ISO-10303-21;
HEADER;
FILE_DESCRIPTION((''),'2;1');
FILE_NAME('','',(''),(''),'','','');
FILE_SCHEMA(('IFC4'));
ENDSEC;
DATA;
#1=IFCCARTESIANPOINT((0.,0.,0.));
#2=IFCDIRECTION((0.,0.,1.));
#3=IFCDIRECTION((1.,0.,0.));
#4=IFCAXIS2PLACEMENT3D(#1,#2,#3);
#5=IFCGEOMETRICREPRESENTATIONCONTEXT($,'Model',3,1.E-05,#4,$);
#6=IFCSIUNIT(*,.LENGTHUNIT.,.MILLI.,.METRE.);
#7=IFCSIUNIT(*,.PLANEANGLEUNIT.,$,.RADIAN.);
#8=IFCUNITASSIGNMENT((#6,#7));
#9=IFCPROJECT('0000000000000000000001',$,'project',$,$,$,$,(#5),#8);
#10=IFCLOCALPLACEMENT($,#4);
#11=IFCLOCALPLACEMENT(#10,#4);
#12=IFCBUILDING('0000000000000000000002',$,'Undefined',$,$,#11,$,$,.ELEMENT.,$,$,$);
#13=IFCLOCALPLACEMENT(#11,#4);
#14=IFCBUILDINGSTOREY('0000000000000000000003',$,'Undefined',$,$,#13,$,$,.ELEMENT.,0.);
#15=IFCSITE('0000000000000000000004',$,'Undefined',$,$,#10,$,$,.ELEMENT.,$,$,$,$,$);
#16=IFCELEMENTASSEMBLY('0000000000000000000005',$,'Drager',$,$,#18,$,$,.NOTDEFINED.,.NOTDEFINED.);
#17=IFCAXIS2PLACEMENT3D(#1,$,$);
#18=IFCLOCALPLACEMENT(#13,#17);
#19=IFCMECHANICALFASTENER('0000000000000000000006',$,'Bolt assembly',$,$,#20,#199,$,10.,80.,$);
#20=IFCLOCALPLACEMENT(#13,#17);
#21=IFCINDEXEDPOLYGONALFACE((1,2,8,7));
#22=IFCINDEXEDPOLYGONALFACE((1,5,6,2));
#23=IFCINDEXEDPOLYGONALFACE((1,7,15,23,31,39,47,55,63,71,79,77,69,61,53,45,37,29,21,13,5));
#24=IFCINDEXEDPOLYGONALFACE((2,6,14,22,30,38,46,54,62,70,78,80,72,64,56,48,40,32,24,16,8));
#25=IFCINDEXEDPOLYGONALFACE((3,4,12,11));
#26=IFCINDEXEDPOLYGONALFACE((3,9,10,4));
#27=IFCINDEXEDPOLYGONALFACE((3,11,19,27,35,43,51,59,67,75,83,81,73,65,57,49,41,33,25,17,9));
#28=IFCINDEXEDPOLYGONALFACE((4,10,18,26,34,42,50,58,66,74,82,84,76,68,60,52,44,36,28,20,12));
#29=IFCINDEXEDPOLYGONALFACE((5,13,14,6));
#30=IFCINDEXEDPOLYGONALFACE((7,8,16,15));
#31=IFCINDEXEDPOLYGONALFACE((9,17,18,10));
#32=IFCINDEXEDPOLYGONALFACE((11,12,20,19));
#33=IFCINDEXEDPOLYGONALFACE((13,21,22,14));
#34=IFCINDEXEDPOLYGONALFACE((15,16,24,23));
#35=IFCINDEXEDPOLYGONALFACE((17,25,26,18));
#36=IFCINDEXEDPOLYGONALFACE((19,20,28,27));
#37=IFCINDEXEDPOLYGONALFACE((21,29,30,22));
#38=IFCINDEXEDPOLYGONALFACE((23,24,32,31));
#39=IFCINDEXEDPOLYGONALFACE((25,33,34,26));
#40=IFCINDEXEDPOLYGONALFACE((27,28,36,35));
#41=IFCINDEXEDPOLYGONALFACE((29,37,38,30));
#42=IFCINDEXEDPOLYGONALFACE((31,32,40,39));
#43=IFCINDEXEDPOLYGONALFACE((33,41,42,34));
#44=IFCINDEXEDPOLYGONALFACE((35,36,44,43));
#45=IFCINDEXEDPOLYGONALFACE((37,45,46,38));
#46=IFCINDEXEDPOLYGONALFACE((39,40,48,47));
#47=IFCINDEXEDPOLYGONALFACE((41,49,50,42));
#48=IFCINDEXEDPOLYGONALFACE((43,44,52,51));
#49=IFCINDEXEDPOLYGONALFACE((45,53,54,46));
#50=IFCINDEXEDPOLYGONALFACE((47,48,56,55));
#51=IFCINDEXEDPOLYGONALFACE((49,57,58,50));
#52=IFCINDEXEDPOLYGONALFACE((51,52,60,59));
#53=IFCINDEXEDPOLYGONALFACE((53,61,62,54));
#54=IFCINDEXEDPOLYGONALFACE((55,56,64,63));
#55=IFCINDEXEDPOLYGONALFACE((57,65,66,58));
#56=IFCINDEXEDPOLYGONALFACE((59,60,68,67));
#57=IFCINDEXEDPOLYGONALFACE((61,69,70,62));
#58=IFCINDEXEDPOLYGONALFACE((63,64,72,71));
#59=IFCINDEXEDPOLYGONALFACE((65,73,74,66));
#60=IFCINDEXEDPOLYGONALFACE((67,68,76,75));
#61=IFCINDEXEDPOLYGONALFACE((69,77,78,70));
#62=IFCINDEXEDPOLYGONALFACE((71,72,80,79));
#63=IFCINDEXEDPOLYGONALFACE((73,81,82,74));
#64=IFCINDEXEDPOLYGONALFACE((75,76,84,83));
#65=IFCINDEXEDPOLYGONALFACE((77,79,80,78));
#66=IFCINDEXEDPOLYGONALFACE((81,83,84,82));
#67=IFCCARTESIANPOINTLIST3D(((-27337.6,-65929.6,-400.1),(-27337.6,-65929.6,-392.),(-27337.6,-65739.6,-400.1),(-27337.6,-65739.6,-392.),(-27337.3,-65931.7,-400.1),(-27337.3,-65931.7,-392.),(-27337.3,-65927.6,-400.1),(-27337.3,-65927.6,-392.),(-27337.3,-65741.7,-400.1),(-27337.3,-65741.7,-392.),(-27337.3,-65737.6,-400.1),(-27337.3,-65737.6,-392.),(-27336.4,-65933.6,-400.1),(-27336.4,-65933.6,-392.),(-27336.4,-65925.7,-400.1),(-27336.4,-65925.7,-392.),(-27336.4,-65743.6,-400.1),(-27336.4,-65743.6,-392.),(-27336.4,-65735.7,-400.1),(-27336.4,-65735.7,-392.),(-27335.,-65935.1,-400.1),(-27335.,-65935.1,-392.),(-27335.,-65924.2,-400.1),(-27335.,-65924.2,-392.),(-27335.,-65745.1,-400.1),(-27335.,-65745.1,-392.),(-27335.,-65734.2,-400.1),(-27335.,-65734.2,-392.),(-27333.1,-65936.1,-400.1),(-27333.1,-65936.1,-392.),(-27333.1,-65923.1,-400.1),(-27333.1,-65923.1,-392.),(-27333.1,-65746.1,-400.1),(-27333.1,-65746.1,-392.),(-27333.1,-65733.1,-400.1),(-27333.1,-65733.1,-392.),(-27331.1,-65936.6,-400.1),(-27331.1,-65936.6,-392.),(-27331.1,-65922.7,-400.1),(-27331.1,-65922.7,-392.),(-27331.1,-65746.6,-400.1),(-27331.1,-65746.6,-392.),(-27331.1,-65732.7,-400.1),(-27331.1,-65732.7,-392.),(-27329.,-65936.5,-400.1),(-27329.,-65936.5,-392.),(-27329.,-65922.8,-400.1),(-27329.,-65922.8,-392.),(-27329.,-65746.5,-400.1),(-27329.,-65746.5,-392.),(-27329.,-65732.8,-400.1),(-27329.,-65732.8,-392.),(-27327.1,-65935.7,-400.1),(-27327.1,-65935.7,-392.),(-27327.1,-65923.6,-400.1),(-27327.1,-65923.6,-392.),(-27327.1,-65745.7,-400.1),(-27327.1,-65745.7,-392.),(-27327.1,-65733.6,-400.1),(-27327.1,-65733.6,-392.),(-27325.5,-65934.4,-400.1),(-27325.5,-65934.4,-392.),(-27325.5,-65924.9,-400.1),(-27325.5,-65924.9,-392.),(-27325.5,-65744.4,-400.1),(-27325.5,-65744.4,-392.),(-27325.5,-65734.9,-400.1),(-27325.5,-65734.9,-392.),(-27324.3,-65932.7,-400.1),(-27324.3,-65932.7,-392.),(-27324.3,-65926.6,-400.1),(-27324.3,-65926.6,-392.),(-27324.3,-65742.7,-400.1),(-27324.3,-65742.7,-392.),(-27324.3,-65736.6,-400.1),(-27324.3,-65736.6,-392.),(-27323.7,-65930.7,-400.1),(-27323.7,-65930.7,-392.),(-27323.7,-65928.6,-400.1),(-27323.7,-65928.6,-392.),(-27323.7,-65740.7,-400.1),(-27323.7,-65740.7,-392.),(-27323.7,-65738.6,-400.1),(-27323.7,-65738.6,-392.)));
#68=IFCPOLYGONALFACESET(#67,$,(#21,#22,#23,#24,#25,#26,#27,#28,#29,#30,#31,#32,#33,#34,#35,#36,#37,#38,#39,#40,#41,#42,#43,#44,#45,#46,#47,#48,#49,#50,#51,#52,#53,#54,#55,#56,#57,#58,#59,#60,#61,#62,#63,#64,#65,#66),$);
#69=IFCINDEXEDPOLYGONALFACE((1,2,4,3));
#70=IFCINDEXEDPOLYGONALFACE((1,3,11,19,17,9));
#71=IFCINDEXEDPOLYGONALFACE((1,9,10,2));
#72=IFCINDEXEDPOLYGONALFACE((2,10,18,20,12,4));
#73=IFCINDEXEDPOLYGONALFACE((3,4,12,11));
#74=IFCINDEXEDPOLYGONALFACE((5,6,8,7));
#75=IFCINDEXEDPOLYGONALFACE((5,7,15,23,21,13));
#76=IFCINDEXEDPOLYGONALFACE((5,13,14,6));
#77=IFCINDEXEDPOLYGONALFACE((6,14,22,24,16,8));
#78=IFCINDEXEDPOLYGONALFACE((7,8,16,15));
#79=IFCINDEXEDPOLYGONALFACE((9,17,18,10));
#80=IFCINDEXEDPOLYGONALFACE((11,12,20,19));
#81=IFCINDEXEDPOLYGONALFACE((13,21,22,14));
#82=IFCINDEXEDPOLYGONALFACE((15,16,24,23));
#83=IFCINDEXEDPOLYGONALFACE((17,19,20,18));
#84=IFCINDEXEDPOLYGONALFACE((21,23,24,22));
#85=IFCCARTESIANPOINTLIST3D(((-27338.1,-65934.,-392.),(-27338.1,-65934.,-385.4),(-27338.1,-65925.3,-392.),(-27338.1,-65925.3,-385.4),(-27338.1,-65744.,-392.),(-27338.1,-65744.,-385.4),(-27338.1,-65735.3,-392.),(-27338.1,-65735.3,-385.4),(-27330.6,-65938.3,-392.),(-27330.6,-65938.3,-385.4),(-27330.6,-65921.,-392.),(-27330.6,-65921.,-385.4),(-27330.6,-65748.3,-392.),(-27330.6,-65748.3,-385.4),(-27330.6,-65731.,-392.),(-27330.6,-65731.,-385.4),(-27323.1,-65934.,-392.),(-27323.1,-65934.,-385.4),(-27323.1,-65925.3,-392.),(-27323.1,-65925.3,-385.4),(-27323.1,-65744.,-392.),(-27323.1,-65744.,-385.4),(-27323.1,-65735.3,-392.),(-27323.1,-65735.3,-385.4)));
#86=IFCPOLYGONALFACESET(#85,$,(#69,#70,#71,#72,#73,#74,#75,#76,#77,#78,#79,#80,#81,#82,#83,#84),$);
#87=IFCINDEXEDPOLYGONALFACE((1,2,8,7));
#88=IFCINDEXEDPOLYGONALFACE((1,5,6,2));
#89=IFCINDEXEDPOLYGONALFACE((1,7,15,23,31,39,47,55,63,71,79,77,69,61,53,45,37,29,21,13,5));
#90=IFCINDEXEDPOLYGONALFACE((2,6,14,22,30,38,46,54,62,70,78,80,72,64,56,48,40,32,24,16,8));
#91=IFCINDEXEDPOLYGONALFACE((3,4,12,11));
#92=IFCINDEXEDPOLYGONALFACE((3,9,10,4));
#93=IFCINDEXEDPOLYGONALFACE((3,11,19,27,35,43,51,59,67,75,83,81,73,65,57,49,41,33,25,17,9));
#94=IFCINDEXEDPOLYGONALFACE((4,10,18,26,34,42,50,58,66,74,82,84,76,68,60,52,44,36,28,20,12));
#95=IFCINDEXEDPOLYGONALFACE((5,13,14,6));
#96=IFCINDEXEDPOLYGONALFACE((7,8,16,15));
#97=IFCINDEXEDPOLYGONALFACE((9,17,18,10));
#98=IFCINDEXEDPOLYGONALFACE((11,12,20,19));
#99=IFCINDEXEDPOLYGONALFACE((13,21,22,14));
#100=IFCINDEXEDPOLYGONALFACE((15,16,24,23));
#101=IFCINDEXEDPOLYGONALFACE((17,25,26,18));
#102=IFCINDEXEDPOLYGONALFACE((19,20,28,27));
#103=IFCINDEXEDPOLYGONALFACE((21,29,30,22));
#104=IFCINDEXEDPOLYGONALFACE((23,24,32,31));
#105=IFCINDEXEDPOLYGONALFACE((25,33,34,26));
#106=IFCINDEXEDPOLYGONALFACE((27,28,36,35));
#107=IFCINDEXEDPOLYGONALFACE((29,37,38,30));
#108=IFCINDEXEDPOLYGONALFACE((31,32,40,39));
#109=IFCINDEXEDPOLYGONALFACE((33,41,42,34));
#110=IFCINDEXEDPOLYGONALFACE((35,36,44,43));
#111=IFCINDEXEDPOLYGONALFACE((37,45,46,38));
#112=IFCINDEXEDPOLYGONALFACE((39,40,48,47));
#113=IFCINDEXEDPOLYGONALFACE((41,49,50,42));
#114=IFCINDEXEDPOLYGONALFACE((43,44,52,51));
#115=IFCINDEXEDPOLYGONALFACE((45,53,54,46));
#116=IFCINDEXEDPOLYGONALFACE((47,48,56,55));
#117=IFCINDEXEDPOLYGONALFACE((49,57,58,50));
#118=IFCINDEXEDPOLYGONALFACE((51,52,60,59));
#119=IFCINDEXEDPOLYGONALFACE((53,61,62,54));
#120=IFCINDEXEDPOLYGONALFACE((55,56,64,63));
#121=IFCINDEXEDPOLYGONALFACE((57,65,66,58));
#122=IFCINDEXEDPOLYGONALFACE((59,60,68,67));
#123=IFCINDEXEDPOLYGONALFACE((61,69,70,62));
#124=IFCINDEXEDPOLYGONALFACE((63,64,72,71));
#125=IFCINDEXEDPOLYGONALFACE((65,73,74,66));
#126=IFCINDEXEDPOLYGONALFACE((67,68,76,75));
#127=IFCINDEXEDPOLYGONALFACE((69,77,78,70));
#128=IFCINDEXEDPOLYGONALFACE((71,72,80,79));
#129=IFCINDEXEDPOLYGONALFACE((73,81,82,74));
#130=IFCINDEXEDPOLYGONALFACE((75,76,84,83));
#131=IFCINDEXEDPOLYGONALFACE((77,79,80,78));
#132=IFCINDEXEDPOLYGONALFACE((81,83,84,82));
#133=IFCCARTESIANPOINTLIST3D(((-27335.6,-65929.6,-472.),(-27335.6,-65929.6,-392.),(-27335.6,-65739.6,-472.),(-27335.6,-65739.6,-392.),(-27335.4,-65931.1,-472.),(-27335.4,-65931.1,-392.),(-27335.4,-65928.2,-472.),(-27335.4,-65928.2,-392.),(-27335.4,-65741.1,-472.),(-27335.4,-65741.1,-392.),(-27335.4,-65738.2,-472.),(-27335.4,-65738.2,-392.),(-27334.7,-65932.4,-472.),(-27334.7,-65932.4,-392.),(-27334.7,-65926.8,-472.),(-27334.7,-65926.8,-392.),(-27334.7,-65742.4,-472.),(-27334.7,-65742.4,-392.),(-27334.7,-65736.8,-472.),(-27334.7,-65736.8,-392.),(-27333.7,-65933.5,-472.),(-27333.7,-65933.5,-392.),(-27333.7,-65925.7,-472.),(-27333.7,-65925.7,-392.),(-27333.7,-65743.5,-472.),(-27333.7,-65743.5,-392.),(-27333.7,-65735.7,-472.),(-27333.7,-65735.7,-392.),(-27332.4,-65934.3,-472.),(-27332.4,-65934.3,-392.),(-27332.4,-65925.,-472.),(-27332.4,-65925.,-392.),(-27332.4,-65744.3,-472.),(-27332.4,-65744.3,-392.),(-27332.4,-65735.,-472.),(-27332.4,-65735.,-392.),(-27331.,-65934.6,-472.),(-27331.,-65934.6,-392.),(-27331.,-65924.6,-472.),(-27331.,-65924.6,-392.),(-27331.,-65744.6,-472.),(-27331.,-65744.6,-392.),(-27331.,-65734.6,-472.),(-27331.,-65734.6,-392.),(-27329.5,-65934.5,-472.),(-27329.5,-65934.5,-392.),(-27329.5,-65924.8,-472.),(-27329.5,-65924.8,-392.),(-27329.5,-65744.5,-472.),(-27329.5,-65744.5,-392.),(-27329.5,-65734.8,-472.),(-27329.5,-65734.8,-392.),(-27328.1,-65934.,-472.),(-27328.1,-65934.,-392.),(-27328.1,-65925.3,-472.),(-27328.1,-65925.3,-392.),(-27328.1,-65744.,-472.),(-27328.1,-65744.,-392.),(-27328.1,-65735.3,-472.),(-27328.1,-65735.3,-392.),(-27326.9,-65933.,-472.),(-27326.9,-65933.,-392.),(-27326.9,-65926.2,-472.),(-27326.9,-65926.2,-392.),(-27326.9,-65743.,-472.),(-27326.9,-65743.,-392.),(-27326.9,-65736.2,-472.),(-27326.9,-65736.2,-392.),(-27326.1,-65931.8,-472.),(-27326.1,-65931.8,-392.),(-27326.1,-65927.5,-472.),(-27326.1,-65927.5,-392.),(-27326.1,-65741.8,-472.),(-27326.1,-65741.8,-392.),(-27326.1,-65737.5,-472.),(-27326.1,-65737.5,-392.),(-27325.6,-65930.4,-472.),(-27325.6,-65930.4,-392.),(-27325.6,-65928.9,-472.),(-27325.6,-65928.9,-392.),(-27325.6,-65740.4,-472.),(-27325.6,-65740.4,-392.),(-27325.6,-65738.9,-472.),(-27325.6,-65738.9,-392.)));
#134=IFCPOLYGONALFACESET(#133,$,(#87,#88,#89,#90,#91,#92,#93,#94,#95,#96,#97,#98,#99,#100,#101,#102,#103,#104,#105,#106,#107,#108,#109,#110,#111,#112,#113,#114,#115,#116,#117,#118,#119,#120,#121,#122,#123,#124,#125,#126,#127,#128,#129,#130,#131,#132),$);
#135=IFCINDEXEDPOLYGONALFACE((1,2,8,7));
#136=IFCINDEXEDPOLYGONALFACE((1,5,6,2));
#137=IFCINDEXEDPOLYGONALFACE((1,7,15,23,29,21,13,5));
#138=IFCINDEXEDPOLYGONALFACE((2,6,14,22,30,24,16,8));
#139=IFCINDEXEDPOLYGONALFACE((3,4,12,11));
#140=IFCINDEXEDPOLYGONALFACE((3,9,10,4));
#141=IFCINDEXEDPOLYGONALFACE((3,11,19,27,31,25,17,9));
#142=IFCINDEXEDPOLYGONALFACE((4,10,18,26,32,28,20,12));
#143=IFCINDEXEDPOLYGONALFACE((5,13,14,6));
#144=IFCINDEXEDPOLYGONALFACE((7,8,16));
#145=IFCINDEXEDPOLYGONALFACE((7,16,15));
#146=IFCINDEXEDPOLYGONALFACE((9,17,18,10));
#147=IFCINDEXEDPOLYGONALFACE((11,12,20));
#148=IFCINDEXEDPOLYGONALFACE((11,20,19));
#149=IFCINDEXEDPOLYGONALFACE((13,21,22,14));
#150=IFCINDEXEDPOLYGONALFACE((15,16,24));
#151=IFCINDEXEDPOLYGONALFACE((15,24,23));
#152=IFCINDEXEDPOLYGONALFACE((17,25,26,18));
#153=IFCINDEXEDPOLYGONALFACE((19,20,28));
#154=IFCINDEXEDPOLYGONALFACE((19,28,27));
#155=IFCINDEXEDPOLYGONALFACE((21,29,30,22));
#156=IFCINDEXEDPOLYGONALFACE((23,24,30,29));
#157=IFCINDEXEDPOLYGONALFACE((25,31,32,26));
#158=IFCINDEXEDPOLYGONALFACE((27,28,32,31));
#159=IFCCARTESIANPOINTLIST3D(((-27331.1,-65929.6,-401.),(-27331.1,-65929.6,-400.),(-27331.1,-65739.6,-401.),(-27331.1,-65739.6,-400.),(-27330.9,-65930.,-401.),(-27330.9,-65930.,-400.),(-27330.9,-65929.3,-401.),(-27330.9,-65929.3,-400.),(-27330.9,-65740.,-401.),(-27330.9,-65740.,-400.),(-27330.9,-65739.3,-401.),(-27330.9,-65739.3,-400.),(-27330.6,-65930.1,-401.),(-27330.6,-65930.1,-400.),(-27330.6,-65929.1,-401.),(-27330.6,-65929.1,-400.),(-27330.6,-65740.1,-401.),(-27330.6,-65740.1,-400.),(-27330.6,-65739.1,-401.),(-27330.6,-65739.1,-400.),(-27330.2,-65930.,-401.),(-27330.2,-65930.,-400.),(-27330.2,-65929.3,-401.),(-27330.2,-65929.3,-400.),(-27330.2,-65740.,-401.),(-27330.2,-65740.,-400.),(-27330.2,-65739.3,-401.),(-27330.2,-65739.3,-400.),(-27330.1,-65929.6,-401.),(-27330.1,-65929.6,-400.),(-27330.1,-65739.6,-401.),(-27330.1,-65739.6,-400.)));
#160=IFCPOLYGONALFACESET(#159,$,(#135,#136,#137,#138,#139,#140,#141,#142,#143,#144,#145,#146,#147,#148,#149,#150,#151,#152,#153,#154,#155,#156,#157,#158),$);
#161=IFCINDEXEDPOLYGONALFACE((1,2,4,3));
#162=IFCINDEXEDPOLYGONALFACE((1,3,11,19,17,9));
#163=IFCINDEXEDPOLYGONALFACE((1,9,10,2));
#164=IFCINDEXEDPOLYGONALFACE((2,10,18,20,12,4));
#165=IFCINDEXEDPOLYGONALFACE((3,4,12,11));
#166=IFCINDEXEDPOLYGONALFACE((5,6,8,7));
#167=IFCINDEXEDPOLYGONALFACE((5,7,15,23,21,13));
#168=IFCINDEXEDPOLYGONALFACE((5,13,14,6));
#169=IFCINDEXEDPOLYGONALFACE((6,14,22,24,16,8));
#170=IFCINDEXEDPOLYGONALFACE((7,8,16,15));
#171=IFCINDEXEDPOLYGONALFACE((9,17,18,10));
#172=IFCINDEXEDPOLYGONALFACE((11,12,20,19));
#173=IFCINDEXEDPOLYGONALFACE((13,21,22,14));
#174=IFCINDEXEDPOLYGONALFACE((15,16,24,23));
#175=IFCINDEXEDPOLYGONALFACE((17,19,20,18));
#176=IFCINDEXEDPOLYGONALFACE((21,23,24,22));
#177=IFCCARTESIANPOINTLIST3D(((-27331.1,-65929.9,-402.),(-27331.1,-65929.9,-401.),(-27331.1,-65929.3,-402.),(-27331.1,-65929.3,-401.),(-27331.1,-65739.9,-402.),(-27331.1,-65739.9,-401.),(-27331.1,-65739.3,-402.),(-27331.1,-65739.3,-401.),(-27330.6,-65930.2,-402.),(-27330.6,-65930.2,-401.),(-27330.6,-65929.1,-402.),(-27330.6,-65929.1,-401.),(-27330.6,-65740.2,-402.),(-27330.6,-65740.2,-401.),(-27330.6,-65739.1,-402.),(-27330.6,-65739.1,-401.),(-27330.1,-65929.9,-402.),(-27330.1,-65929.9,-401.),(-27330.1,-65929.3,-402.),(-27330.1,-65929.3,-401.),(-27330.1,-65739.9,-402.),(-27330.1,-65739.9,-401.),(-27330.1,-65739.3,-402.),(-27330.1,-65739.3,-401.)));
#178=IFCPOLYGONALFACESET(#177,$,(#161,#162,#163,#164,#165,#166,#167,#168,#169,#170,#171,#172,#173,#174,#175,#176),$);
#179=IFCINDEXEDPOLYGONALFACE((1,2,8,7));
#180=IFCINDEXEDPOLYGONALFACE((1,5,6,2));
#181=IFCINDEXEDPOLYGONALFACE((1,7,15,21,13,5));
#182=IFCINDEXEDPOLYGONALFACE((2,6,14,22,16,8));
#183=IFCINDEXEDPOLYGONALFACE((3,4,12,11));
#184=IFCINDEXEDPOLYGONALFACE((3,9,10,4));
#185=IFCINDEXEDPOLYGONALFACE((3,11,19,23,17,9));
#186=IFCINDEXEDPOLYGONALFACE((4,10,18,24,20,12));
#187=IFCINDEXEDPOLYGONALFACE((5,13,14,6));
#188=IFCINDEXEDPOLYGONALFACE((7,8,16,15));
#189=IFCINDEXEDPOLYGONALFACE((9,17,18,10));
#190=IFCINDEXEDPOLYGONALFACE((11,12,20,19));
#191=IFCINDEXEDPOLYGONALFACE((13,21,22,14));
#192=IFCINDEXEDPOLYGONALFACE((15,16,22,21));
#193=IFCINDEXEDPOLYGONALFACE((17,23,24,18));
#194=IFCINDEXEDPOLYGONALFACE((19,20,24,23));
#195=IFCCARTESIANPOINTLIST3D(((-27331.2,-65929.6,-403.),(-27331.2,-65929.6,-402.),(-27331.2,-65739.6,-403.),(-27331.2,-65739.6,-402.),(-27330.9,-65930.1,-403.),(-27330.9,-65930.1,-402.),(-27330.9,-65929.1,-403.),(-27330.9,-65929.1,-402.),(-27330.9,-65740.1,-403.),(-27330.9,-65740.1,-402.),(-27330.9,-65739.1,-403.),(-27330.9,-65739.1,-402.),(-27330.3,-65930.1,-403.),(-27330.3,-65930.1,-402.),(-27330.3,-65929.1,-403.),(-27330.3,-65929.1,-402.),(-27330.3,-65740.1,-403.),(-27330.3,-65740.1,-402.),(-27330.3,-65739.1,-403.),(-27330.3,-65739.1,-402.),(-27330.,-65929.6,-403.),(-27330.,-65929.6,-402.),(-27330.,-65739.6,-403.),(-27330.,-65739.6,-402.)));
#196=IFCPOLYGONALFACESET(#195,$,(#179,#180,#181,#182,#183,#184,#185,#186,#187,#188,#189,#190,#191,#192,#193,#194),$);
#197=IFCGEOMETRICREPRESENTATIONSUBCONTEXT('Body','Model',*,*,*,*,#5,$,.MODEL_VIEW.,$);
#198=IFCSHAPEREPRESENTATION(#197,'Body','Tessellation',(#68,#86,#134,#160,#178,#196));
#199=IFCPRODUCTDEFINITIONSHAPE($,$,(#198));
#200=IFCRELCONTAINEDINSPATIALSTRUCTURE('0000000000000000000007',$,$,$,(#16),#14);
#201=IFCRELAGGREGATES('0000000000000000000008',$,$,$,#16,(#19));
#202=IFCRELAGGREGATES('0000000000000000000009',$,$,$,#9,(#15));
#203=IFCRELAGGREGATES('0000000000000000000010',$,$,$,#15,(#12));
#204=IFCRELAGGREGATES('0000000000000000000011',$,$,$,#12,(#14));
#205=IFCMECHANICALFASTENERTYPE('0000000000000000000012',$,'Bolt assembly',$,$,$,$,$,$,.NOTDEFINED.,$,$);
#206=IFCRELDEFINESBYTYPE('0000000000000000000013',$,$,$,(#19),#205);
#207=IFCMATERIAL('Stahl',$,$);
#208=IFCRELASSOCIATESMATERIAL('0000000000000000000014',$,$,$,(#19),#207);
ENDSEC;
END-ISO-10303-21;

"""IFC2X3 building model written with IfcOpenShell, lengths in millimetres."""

from ifc_helpers import new_model, si_unit, frame, origin_with_axes, origin_2d_with_axis, place, context, subcontext, project, spatial, polyline, circle, outline, extrude, source, transform, mapped, material, type_object, element, aggregate, save


model = new_model("IFC2X3")

# Units and contexts
model_context = context("Model", 3, precision=1e-05, world=origin_with_axes())
body_context = subcontext(model_context, "Body", "Model", "MODEL_VIEW")
ifc_project = project(units=[si_unit("LENGTHUNIT", "METRE", prefix="MILLI"), si_unit("PLANEANGLEUNIT", "RADIAN")], contexts=[model_context])

# Site, building, storey
site_placement = place(None, origin_with_axes())
site = spatial("IfcSite", under=ifc_project, at=site_placement, Name="Undefined", CompositionType="ELEMENT")
building_placement = place(site_placement, origin_with_axes())
building = spatial("IfcBuilding", under=site, at=building_placement, Name="Undefined", CompositionType="ELEMENT")
storey_placement = place(building_placement, origin_with_axes())
storey = spatial("IfcBuildingStorey", under=building, at=storey_placement, Name="Undefined", CompositionType="ELEMENT", Elevation=0.0)

# Element assembly
assembly_1_placement = place(storey_placement, origin_with_axes())
assembly_1 = element("IfcElementAssembly", 1, at=assembly_1_placement, inside=storey, Name="Drager", AssemblyPlace="NOTDEFINED", PredefinedType="NOTDEFINED")

# Mechanical fastener
mechanical_fastener_type = type_object("IfcMechanicalFastenerType", Name="Bolt assembly")
ifc_material_1 = material(Name="Stahl")
shared_shape_1 = source(origin_with_axes(), body_context, "Body", "SweptSolid", [
    extrude(circle(Radius=7.0, at=origin_2d_with_axis()), frame((0.0, 0.0, 0.0), z_axis=(0.0, 1.0, 0.0), x_axis=(1.0, 0.0, 0.0)), (0.0, 0.0, 1.0), 8.1),
    extrude(outline(polyline([(7.5, -4.3), (7.5, 4.3), (0.0, 8.7), (-7.5, 4.3), (-7.5, -4.3), (0.0, -8.7), (7.5, -4.3)])), frame((0.0, -6.6, 0.0), z_axis=(0.0, 1.0, 0.0), x_axis=(1.0, 0.0, 0.0)), (0.0, 0.0, 1.0), 6.6),
    extrude(circle(Radius=5.0, at=origin_2d_with_axis()), frame((0.0, 0.0, 0.0), z_axis=(0.0, 1.0, 0.0), x_axis=(1.0, 0.0, 0.0)), (0.0, 0.0, 1.0), 80.0),
    extrude(circle(Radius=0.5, at=origin_2d_with_axis()), frame((0.0, 8.0, 0.0), z_axis=(0.0, 1.0, 0.0), x_axis=(1.0, 0.0, 0.0)), (0.0, 0.0, 1.0), 1.0),
    extrude(outline(polyline([(0.5, -0.3), (0.5, 0.3), (0.0, 0.6), (-0.5, 0.3), (-0.5, -0.3), (0.0, -0.6), (0.5, -0.3)])), frame((0.0, 9.0, 0.0), z_axis=(0.0, 1.0, 0.0), x_axis=(1.0, 0.0, 0.0)), (0.0, 0.0, 1.0), 1.0),
    extrude(outline(polyline([(0.6, 0.0), (0.3, 0.5), (-0.3, 0.5), (-0.6, 0.0), (-0.3, -0.5), (0.3, -0.5), (0.6, 0.0)])), frame((0.0, 10.0, 0.0), z_axis=(0.0, 1.0, 0.0), x_axis=(1.0, 0.0, 0.0)), (0.0, 0.0, 1.0), 1.0),
])
mechanical_fastener_1_placement = place(assembly_1_placement, frame((-27330.6, -65834.6, -392.0), z_axis=(0.0, -1.0, 0.0), x_axis=(-1.0, 0.0, 0.0)))
mechanical_fastener_1 = element("IfcMechanicalFastener", 2, at=mechanical_fastener_1_placement, type_object=mechanical_fastener_type, material=ifc_material_1, Name="Bolt assembly", NominalDiameter=10.0, NominalLength=80.0, context=body_context, shape_type="MappedRepresentation", body=[
    mapped(shared_shape_1, transform((0.0, 0.0, -95.0))),
    mapped(shared_shape_1, transform((0.0, 0.0, 95.0))),
])
aggregate(assembly_1, [mechanical_fastener_1])

save(model, "model.ifc")
